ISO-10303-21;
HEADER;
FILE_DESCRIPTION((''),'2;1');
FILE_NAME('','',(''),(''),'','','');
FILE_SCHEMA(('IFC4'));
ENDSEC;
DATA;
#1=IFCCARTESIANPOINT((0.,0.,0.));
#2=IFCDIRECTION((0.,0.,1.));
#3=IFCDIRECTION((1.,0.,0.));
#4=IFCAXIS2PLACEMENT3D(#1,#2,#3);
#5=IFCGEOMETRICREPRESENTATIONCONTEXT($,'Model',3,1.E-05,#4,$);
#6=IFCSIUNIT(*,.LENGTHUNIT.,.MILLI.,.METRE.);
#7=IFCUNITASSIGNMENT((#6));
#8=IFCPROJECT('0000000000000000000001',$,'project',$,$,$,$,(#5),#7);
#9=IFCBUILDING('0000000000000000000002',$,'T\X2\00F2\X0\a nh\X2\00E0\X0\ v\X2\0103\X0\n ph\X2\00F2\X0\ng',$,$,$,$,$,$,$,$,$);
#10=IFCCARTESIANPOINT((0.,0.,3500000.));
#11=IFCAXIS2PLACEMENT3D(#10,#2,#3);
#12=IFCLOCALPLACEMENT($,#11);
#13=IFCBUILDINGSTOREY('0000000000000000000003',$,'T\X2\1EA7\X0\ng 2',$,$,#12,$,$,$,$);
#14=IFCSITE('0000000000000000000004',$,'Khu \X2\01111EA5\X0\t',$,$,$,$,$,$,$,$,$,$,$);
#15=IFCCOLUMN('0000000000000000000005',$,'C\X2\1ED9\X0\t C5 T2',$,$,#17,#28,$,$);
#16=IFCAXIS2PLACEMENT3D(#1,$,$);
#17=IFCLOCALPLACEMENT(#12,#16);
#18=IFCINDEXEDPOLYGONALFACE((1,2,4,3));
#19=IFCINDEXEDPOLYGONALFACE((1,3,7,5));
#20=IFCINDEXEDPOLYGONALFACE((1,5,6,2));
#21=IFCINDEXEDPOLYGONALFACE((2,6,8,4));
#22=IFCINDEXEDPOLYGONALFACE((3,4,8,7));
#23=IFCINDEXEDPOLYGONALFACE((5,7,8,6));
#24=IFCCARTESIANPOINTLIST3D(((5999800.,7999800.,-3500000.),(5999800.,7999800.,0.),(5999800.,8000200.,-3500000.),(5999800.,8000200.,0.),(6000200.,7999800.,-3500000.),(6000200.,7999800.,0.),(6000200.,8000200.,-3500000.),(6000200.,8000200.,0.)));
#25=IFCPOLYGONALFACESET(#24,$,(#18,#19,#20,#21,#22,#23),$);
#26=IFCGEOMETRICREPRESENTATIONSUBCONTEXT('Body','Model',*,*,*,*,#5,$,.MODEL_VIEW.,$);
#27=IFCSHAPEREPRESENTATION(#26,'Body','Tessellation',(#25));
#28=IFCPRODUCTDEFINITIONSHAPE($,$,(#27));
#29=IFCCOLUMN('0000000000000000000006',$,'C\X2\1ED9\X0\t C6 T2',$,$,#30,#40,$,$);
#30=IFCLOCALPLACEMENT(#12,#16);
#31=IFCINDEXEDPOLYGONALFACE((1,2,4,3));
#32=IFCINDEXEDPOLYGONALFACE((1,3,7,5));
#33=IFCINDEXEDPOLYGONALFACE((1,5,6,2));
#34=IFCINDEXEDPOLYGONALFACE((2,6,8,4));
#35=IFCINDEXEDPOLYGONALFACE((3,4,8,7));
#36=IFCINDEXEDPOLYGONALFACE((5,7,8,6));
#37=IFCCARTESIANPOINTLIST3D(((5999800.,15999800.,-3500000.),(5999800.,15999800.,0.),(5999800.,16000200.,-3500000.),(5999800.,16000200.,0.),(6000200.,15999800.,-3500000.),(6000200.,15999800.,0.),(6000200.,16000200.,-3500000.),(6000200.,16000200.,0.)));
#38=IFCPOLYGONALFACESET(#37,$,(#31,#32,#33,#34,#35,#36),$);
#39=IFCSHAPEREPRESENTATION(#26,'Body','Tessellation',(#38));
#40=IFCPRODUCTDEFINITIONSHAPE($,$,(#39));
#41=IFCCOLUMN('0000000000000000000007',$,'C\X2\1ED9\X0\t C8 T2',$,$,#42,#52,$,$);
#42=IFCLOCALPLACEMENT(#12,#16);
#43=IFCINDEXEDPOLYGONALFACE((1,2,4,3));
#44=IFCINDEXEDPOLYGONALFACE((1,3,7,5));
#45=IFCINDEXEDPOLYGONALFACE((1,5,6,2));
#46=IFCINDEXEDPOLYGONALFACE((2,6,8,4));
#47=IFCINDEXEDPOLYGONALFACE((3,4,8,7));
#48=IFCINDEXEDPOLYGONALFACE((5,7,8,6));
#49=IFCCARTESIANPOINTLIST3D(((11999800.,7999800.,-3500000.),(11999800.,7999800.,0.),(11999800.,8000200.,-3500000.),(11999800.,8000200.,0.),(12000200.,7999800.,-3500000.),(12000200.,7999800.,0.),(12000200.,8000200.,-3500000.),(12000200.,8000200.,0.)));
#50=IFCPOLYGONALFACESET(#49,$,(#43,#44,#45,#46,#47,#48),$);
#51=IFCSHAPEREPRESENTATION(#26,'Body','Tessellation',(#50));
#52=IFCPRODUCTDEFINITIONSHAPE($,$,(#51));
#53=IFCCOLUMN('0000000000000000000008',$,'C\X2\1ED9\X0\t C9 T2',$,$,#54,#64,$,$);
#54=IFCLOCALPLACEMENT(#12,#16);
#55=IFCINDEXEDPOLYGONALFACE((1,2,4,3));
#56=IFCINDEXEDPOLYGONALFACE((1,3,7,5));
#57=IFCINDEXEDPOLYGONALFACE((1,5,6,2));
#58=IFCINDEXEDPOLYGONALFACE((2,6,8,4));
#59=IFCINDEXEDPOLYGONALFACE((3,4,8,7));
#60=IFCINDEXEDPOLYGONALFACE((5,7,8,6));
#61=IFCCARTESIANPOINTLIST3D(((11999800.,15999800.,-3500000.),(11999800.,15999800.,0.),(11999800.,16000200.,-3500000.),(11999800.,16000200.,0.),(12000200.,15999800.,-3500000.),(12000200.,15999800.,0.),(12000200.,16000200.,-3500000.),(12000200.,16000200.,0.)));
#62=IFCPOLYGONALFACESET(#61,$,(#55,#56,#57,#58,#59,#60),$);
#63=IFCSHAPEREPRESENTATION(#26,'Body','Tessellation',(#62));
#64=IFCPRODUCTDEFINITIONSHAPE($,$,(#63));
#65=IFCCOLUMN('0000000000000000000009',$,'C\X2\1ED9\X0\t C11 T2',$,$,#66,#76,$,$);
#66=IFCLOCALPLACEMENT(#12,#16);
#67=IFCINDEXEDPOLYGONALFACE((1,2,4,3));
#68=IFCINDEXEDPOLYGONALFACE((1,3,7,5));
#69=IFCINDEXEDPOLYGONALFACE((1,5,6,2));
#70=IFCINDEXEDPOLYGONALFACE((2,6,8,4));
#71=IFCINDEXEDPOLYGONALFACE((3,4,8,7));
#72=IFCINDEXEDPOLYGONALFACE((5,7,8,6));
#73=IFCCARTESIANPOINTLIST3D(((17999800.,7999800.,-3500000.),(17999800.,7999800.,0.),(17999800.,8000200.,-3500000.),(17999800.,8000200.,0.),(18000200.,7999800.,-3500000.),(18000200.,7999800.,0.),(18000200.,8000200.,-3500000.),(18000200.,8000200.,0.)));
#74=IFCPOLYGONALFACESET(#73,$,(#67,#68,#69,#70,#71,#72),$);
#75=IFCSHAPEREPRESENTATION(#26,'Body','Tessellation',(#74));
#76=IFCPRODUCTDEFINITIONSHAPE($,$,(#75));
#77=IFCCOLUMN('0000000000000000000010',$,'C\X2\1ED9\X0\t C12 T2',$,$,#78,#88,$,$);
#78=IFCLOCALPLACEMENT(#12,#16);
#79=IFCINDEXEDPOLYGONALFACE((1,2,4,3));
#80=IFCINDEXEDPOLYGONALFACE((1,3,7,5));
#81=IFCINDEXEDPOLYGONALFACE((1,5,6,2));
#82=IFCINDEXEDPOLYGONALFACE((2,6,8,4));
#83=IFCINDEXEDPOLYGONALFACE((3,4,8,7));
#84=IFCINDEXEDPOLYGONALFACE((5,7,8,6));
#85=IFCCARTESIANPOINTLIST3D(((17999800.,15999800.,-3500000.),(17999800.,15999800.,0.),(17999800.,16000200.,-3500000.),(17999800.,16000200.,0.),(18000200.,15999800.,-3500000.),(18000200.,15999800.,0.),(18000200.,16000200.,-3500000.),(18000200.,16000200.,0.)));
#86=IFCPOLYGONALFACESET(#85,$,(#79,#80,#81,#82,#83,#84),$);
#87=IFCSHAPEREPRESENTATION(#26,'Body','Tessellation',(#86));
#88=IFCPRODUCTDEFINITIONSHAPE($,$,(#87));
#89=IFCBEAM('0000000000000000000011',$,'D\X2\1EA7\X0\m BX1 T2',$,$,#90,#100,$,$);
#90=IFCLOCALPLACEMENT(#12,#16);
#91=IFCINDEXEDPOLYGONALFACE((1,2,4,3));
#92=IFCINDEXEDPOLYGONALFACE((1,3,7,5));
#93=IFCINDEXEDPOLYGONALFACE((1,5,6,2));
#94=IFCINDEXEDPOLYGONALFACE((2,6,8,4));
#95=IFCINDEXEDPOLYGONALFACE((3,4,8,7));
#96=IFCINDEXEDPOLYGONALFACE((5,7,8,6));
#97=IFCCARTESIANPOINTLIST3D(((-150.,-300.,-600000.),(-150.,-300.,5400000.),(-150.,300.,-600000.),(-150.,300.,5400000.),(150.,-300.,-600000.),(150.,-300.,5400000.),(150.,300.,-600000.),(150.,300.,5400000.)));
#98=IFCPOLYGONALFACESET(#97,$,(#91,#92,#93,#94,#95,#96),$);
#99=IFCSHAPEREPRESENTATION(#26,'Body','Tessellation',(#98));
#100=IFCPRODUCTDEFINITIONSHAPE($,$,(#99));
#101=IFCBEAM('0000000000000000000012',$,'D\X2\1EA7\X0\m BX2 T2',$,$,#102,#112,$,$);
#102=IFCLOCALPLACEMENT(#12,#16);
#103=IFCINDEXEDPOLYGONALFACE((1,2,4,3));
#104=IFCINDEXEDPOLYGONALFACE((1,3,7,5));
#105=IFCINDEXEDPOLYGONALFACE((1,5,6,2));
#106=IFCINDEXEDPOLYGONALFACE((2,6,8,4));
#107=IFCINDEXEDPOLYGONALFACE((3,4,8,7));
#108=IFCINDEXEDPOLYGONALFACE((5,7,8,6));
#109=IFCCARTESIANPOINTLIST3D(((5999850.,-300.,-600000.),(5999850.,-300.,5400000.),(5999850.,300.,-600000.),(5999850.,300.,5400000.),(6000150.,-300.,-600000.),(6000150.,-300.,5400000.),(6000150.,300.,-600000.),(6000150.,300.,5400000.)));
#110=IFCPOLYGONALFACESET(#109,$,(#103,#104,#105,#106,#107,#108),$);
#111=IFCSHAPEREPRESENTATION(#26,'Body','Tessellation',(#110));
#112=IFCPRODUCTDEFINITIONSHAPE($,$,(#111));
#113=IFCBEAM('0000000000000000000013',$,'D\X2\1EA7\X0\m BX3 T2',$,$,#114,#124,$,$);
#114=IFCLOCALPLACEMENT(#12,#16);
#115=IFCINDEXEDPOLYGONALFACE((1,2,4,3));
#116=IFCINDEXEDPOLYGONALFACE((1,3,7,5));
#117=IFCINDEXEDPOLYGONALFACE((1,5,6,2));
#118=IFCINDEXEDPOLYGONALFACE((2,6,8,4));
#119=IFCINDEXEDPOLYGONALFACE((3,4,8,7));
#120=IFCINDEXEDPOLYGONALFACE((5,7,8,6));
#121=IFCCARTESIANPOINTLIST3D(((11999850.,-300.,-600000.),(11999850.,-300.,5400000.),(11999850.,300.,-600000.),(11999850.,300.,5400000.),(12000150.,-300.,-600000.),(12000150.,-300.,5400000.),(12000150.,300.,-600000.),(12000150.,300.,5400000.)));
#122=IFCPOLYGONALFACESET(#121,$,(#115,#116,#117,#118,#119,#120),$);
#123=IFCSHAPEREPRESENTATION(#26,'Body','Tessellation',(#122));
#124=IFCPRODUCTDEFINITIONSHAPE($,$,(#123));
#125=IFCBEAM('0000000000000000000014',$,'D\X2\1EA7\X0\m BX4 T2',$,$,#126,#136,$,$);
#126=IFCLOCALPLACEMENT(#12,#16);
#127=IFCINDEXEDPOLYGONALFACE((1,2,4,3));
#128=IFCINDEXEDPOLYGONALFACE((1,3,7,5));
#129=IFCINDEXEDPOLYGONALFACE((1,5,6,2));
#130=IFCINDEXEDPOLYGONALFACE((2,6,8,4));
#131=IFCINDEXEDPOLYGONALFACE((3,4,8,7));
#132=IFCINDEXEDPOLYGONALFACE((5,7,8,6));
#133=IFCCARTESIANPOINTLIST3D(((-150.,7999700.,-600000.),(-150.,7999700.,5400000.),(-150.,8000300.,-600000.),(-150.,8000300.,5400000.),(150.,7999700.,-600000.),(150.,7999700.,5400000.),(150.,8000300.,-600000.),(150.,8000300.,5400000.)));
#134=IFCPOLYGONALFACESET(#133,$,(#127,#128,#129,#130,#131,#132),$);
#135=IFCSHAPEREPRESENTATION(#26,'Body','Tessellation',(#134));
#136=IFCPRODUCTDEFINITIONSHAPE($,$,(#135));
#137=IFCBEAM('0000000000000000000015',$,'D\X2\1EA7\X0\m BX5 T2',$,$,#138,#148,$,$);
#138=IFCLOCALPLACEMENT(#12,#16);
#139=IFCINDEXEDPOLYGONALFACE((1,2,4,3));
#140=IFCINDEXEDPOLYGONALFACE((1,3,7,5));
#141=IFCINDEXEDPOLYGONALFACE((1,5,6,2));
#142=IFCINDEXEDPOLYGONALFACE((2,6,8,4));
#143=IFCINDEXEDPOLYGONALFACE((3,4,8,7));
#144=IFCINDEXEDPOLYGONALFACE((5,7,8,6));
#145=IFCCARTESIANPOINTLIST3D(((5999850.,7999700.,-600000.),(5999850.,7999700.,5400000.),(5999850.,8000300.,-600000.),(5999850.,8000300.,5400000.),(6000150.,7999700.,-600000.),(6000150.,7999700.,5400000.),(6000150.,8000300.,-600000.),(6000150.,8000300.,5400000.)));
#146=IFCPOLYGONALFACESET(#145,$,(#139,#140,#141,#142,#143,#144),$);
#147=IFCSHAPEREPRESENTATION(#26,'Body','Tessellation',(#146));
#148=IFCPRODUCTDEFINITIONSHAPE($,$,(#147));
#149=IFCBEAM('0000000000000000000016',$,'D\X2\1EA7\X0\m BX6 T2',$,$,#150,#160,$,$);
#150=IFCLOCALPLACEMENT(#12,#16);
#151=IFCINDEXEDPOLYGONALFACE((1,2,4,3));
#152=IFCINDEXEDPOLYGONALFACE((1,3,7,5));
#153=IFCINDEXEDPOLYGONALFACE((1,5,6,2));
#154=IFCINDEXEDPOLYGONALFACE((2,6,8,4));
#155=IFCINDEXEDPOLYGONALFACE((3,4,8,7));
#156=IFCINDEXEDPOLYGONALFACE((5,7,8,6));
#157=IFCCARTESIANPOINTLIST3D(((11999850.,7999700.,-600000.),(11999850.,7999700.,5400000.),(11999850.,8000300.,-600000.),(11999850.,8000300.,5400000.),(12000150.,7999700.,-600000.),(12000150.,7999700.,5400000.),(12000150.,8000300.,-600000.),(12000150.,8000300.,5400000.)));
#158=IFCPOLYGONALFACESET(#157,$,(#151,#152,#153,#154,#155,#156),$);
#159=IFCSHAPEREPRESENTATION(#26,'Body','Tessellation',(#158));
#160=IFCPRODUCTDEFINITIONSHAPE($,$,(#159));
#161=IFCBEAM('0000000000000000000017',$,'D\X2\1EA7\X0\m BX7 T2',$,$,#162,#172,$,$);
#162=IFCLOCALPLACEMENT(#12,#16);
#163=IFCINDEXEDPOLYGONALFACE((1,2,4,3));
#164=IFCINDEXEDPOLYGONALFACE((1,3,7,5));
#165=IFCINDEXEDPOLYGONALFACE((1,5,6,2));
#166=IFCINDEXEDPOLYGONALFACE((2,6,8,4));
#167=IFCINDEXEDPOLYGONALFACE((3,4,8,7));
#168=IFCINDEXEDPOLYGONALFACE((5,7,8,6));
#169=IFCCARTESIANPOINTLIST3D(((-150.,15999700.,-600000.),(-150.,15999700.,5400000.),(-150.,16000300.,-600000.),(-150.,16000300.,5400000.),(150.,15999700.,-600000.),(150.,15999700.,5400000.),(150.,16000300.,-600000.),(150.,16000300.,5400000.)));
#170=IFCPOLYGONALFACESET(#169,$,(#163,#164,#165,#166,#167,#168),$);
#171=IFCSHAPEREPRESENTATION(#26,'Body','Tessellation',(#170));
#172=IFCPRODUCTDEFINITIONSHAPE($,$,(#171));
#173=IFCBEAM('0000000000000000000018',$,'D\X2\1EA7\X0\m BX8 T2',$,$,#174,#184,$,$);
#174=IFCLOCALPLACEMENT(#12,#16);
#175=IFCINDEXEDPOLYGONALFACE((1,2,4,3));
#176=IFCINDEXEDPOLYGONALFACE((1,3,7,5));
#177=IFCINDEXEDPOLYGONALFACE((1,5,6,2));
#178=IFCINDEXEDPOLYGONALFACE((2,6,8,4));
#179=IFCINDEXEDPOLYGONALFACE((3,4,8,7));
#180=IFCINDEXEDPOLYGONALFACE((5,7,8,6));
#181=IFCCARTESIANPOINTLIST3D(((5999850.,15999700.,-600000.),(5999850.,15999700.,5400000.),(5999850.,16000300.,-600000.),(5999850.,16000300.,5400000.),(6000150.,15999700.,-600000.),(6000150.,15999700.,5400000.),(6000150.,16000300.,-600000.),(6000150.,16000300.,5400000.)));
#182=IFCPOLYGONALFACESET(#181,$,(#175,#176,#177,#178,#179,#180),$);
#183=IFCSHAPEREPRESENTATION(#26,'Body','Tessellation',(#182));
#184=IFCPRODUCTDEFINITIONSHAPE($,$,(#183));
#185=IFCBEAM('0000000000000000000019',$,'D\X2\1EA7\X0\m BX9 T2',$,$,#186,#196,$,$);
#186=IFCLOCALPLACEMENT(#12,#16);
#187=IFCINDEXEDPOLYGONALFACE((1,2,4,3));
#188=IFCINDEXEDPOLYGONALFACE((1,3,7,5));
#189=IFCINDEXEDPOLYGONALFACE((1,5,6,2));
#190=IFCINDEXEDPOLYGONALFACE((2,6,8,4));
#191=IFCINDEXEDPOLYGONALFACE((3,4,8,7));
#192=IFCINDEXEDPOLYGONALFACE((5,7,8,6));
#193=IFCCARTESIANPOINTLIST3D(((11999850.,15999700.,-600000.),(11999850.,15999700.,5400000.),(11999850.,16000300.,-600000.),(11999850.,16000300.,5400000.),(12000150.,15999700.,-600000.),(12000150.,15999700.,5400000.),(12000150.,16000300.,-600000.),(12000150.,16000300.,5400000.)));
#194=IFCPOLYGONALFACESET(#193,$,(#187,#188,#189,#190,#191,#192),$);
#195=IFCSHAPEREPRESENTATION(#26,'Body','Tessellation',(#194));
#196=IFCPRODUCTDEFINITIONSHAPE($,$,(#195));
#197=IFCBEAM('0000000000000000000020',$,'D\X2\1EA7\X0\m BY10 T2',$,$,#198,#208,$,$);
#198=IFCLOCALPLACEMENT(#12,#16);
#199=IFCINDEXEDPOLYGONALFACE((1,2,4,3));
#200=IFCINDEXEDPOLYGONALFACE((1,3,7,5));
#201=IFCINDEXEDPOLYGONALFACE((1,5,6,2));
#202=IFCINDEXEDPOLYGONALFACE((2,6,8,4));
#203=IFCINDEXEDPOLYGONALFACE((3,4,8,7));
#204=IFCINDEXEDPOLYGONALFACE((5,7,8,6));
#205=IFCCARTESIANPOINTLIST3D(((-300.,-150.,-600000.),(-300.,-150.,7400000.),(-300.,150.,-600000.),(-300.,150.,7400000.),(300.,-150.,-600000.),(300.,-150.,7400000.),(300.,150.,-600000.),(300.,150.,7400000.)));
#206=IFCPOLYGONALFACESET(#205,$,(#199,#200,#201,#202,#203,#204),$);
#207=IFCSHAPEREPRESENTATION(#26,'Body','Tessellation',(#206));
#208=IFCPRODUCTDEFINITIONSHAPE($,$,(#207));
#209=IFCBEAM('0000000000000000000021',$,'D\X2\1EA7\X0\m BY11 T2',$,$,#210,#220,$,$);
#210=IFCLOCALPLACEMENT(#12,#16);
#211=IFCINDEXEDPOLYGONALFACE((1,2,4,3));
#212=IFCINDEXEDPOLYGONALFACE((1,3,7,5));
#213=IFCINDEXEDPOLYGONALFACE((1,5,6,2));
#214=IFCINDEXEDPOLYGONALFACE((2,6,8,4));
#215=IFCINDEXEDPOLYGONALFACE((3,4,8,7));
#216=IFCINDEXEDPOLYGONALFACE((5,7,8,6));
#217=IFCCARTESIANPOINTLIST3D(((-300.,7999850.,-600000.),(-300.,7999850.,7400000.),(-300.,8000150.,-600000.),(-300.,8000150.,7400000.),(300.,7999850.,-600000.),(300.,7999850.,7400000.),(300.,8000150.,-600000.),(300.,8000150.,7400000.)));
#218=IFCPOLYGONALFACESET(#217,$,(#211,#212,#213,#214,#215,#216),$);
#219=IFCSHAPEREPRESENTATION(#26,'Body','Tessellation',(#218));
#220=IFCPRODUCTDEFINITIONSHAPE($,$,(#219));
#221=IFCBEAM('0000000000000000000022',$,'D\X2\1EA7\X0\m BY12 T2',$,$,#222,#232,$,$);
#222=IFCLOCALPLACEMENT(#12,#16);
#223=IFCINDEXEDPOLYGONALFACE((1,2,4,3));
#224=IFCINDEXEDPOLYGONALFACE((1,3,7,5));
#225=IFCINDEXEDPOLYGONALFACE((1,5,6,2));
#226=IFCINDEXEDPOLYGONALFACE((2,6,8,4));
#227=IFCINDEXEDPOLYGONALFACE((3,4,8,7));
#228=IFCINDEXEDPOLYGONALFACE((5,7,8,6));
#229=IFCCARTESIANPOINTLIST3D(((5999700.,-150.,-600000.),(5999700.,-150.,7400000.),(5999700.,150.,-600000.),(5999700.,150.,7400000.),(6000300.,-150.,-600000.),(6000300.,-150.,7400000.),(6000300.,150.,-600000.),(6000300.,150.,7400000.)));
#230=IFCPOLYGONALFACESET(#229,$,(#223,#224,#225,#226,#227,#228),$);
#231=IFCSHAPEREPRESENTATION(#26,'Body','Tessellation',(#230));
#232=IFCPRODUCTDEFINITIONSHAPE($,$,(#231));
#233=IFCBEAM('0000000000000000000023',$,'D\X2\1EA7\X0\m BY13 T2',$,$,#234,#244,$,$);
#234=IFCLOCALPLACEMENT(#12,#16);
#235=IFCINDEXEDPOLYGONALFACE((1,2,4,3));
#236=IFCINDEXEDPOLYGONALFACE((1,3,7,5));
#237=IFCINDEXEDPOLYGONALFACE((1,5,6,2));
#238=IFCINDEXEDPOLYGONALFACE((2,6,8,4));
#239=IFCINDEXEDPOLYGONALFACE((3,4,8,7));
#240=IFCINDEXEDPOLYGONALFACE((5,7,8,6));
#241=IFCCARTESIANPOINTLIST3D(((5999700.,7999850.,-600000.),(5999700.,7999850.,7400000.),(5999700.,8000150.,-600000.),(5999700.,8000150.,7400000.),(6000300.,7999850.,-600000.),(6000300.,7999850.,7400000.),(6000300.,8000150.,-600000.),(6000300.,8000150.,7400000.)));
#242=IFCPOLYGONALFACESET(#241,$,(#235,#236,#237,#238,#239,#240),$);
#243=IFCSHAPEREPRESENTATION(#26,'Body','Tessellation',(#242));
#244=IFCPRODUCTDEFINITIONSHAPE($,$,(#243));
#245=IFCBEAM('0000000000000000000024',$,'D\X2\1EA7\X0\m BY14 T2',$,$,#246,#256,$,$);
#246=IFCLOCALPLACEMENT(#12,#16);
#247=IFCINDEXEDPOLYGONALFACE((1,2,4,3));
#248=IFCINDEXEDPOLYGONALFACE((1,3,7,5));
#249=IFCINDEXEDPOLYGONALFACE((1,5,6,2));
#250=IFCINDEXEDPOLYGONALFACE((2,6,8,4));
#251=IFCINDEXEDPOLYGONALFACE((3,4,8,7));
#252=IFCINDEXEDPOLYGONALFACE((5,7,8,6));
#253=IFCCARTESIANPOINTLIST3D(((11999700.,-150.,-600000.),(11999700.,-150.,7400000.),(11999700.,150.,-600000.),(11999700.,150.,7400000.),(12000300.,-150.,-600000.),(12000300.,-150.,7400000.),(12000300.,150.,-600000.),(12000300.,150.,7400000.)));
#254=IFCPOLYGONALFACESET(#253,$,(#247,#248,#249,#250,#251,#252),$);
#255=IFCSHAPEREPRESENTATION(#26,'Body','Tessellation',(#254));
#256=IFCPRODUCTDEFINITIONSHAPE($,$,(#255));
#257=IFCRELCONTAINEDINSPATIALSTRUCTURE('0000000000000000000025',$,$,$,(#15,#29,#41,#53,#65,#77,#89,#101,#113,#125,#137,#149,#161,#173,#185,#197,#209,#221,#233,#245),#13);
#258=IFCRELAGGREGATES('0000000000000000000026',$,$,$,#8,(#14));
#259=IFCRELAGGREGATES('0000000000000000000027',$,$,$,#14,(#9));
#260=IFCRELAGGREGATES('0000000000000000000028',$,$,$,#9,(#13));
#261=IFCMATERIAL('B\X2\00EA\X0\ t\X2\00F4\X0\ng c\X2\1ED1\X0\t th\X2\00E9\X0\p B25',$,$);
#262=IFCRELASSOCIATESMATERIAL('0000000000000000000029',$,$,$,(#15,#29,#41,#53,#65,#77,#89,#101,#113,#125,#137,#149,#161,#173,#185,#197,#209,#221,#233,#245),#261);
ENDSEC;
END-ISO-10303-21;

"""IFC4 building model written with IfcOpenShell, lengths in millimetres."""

from ifc_helpers import new_model, entity, si_unit, frame, origin_with_axes, place, context, subcontext, project, spatial, extrude, material, element, save


model = new_model("IFC4")

# Units and contexts
model_context = context("Model", 3, precision=1e-05, world=origin_with_axes())
body_context = subcontext(model_context, "Body", "Model", "MODEL_VIEW")
ifc_project = project(units=[si_unit("LENGTHUNIT", "METRE", prefix="MILLI")], contexts=[model_context])

# Site, building, storey
site = spatial("IfcSite", under=ifc_project, Name="Khu đất")
building = spatial("IfcBuilding", under=site, Name="Tòa nhà văn phòng")
storey_placement = place(None, frame((0.0, 0.0, 3500000.0), z_axis=(0.0, 0.0, 1.0), x_axis=(1.0, 0.0, 0.0)))
storey = spatial("IfcBuildingStorey", under=building, at=storey_placement, Name="Tầng 2")

# Columns
ifc_material_1 = material(Name="Bê tông cốt thép B25")
for number, where, z_axis, x_axis, name in (
    (1, (6000000.0, 8000000.0, -3500000.0), (0.0, 0.0, 1.0), (1.0, 0.0, 0.0), "Cột C5 T2"),
    (2, (6000000.0, 16000000.0, -3500000.0), (0.0, 0.0, 1.0), (1.0, 0.0, 0.0), "Cột C6 T2"),
    (3, (12000000.0, 8000000.0, -3500000.0), (0.0, 0.0, 1.0), (1.0, 0.0, 0.0), "Cột C8 T2"),
    (4, (12000000.0, 16000000.0, -3500000.0), (0.0, 0.0, 1.0), (1.0, 0.0, 0.0), "Cột C9 T2"),
    (5, (18000000.0, 8000000.0, -3500000.0), (0.0, 0.0, 1.0), (1.0, 0.0, 0.0), "Cột C11 T2"),
    (6, (18000000.0, 16000000.0, -3500000.0), (0.0, 0.0, 1.0), (1.0, 0.0, 0.0), "Cột C12 T2"),
):
    element("IfcColumn", number, at=place(storey_placement, frame(where, z_axis=z_axis, x_axis=x_axis)), inside=storey, material=ifc_material_1, Name=name, context=body_context, shape_type="SweptSolid", body=[
        extrude(entity("IfcRectangleProfileDef", None, None, None, 400.0, 400.0), origin_with_axes(), (0.0, 0.0, 1.0), 3500000.0),
    ])

# Beams
for number, where, z_axis, x_axis, name in (
    (7, (0.0, 0.0, -600000.0), (0.0, 0.0, 1.0), (1.0, 0.0, 0.0), "Dầm BX1 T2"),
    (8, (6000000.0, 0.0, -600000.0), (0.0, 0.0, 1.0), (1.0, 0.0, 0.0), "Dầm BX2 T2"),
    (9, (12000000.0, 0.0, -600000.0), (0.0, 0.0, 1.0), (1.0, 0.0, 0.0), "Dầm BX3 T2"),
    (10, (0.0, 8000000.0, -600000.0), (0.0, 0.0, 1.0), (1.0, 0.0, 0.0), "Dầm BX4 T2"),
    (11, (6000000.0, 8000000.0, -600000.0), (0.0, 0.0, 1.0), (1.0, 0.0, 0.0), "Dầm BX5 T2"),
    (12, (12000000.0, 8000000.0, -600000.0), (0.0, 0.0, 1.0), (1.0, 0.0, 0.0), "Dầm BX6 T2"),
    (13, (0.0, 16000000.0, -600000.0), (0.0, 0.0, 1.0), (1.0, 0.0, 0.0), "Dầm BX7 T2"),
    (14, (6000000.0, 16000000.0, -600000.0), (0.0, 0.0, 1.0), (1.0, 0.0, 0.0), "Dầm BX8 T2"),
    (15, (12000000.0, 16000000.0, -600000.0), (0.0, 0.0, 1.0), (1.0, 0.0, 0.0), "Dầm BX9 T2"),
):
    element("IfcBeam", number, at=place(storey_placement, frame(where, z_axis=z_axis, x_axis=x_axis)), inside=storey, material=ifc_material_1, Name=name, context=body_context, shape_type="SweptSolid", body=[
        extrude(entity("IfcRectangleProfileDef", None, None, None, 300.0, 600.0), origin_with_axes(), (0.0, 0.0, 1.0), 6000000.0),
    ])
for number, where, z_axis, x_axis, name in (
    (16, (0.0, 0.0, -600000.0), (0.0, 0.0, 1.0), (0.0, 1.0, 0.0), "Dầm BY10 T2"),
    (17, (0.0, 8000000.0, -600000.0), (0.0, 0.0, 1.0), (0.0, 1.0, 0.0), "Dầm BY11 T2"),
    (18, (6000000.0, 0.0, -600000.0), (0.0, 0.0, 1.0), (0.0, 1.0, 0.0), "Dầm BY12 T2"),
    (19, (6000000.0, 8000000.0, -600000.0), (0.0, 0.0, 1.0), (0.0, 1.0, 0.0), "Dầm BY13 T2"),
    (20, (12000000.0, 0.0, -600000.0), (0.0, 0.0, 1.0), (0.0, 1.0, 0.0), "Dầm BY14 T2"),
):
    element("IfcBeam", number, at=place(storey_placement, frame(where, z_axis=z_axis, x_axis=x_axis)), inside=storey, material=ifc_material_1, Name=name, context=body_context, shape_type="SweptSolid", body=[
        extrude(entity("IfcRectangleProfileDef", None, None, None, 300.0, 600.0), origin_with_axes(), (0.0, 0.0, 1.0), 8000000.0),
    ])

save(model, "model.ifc")
